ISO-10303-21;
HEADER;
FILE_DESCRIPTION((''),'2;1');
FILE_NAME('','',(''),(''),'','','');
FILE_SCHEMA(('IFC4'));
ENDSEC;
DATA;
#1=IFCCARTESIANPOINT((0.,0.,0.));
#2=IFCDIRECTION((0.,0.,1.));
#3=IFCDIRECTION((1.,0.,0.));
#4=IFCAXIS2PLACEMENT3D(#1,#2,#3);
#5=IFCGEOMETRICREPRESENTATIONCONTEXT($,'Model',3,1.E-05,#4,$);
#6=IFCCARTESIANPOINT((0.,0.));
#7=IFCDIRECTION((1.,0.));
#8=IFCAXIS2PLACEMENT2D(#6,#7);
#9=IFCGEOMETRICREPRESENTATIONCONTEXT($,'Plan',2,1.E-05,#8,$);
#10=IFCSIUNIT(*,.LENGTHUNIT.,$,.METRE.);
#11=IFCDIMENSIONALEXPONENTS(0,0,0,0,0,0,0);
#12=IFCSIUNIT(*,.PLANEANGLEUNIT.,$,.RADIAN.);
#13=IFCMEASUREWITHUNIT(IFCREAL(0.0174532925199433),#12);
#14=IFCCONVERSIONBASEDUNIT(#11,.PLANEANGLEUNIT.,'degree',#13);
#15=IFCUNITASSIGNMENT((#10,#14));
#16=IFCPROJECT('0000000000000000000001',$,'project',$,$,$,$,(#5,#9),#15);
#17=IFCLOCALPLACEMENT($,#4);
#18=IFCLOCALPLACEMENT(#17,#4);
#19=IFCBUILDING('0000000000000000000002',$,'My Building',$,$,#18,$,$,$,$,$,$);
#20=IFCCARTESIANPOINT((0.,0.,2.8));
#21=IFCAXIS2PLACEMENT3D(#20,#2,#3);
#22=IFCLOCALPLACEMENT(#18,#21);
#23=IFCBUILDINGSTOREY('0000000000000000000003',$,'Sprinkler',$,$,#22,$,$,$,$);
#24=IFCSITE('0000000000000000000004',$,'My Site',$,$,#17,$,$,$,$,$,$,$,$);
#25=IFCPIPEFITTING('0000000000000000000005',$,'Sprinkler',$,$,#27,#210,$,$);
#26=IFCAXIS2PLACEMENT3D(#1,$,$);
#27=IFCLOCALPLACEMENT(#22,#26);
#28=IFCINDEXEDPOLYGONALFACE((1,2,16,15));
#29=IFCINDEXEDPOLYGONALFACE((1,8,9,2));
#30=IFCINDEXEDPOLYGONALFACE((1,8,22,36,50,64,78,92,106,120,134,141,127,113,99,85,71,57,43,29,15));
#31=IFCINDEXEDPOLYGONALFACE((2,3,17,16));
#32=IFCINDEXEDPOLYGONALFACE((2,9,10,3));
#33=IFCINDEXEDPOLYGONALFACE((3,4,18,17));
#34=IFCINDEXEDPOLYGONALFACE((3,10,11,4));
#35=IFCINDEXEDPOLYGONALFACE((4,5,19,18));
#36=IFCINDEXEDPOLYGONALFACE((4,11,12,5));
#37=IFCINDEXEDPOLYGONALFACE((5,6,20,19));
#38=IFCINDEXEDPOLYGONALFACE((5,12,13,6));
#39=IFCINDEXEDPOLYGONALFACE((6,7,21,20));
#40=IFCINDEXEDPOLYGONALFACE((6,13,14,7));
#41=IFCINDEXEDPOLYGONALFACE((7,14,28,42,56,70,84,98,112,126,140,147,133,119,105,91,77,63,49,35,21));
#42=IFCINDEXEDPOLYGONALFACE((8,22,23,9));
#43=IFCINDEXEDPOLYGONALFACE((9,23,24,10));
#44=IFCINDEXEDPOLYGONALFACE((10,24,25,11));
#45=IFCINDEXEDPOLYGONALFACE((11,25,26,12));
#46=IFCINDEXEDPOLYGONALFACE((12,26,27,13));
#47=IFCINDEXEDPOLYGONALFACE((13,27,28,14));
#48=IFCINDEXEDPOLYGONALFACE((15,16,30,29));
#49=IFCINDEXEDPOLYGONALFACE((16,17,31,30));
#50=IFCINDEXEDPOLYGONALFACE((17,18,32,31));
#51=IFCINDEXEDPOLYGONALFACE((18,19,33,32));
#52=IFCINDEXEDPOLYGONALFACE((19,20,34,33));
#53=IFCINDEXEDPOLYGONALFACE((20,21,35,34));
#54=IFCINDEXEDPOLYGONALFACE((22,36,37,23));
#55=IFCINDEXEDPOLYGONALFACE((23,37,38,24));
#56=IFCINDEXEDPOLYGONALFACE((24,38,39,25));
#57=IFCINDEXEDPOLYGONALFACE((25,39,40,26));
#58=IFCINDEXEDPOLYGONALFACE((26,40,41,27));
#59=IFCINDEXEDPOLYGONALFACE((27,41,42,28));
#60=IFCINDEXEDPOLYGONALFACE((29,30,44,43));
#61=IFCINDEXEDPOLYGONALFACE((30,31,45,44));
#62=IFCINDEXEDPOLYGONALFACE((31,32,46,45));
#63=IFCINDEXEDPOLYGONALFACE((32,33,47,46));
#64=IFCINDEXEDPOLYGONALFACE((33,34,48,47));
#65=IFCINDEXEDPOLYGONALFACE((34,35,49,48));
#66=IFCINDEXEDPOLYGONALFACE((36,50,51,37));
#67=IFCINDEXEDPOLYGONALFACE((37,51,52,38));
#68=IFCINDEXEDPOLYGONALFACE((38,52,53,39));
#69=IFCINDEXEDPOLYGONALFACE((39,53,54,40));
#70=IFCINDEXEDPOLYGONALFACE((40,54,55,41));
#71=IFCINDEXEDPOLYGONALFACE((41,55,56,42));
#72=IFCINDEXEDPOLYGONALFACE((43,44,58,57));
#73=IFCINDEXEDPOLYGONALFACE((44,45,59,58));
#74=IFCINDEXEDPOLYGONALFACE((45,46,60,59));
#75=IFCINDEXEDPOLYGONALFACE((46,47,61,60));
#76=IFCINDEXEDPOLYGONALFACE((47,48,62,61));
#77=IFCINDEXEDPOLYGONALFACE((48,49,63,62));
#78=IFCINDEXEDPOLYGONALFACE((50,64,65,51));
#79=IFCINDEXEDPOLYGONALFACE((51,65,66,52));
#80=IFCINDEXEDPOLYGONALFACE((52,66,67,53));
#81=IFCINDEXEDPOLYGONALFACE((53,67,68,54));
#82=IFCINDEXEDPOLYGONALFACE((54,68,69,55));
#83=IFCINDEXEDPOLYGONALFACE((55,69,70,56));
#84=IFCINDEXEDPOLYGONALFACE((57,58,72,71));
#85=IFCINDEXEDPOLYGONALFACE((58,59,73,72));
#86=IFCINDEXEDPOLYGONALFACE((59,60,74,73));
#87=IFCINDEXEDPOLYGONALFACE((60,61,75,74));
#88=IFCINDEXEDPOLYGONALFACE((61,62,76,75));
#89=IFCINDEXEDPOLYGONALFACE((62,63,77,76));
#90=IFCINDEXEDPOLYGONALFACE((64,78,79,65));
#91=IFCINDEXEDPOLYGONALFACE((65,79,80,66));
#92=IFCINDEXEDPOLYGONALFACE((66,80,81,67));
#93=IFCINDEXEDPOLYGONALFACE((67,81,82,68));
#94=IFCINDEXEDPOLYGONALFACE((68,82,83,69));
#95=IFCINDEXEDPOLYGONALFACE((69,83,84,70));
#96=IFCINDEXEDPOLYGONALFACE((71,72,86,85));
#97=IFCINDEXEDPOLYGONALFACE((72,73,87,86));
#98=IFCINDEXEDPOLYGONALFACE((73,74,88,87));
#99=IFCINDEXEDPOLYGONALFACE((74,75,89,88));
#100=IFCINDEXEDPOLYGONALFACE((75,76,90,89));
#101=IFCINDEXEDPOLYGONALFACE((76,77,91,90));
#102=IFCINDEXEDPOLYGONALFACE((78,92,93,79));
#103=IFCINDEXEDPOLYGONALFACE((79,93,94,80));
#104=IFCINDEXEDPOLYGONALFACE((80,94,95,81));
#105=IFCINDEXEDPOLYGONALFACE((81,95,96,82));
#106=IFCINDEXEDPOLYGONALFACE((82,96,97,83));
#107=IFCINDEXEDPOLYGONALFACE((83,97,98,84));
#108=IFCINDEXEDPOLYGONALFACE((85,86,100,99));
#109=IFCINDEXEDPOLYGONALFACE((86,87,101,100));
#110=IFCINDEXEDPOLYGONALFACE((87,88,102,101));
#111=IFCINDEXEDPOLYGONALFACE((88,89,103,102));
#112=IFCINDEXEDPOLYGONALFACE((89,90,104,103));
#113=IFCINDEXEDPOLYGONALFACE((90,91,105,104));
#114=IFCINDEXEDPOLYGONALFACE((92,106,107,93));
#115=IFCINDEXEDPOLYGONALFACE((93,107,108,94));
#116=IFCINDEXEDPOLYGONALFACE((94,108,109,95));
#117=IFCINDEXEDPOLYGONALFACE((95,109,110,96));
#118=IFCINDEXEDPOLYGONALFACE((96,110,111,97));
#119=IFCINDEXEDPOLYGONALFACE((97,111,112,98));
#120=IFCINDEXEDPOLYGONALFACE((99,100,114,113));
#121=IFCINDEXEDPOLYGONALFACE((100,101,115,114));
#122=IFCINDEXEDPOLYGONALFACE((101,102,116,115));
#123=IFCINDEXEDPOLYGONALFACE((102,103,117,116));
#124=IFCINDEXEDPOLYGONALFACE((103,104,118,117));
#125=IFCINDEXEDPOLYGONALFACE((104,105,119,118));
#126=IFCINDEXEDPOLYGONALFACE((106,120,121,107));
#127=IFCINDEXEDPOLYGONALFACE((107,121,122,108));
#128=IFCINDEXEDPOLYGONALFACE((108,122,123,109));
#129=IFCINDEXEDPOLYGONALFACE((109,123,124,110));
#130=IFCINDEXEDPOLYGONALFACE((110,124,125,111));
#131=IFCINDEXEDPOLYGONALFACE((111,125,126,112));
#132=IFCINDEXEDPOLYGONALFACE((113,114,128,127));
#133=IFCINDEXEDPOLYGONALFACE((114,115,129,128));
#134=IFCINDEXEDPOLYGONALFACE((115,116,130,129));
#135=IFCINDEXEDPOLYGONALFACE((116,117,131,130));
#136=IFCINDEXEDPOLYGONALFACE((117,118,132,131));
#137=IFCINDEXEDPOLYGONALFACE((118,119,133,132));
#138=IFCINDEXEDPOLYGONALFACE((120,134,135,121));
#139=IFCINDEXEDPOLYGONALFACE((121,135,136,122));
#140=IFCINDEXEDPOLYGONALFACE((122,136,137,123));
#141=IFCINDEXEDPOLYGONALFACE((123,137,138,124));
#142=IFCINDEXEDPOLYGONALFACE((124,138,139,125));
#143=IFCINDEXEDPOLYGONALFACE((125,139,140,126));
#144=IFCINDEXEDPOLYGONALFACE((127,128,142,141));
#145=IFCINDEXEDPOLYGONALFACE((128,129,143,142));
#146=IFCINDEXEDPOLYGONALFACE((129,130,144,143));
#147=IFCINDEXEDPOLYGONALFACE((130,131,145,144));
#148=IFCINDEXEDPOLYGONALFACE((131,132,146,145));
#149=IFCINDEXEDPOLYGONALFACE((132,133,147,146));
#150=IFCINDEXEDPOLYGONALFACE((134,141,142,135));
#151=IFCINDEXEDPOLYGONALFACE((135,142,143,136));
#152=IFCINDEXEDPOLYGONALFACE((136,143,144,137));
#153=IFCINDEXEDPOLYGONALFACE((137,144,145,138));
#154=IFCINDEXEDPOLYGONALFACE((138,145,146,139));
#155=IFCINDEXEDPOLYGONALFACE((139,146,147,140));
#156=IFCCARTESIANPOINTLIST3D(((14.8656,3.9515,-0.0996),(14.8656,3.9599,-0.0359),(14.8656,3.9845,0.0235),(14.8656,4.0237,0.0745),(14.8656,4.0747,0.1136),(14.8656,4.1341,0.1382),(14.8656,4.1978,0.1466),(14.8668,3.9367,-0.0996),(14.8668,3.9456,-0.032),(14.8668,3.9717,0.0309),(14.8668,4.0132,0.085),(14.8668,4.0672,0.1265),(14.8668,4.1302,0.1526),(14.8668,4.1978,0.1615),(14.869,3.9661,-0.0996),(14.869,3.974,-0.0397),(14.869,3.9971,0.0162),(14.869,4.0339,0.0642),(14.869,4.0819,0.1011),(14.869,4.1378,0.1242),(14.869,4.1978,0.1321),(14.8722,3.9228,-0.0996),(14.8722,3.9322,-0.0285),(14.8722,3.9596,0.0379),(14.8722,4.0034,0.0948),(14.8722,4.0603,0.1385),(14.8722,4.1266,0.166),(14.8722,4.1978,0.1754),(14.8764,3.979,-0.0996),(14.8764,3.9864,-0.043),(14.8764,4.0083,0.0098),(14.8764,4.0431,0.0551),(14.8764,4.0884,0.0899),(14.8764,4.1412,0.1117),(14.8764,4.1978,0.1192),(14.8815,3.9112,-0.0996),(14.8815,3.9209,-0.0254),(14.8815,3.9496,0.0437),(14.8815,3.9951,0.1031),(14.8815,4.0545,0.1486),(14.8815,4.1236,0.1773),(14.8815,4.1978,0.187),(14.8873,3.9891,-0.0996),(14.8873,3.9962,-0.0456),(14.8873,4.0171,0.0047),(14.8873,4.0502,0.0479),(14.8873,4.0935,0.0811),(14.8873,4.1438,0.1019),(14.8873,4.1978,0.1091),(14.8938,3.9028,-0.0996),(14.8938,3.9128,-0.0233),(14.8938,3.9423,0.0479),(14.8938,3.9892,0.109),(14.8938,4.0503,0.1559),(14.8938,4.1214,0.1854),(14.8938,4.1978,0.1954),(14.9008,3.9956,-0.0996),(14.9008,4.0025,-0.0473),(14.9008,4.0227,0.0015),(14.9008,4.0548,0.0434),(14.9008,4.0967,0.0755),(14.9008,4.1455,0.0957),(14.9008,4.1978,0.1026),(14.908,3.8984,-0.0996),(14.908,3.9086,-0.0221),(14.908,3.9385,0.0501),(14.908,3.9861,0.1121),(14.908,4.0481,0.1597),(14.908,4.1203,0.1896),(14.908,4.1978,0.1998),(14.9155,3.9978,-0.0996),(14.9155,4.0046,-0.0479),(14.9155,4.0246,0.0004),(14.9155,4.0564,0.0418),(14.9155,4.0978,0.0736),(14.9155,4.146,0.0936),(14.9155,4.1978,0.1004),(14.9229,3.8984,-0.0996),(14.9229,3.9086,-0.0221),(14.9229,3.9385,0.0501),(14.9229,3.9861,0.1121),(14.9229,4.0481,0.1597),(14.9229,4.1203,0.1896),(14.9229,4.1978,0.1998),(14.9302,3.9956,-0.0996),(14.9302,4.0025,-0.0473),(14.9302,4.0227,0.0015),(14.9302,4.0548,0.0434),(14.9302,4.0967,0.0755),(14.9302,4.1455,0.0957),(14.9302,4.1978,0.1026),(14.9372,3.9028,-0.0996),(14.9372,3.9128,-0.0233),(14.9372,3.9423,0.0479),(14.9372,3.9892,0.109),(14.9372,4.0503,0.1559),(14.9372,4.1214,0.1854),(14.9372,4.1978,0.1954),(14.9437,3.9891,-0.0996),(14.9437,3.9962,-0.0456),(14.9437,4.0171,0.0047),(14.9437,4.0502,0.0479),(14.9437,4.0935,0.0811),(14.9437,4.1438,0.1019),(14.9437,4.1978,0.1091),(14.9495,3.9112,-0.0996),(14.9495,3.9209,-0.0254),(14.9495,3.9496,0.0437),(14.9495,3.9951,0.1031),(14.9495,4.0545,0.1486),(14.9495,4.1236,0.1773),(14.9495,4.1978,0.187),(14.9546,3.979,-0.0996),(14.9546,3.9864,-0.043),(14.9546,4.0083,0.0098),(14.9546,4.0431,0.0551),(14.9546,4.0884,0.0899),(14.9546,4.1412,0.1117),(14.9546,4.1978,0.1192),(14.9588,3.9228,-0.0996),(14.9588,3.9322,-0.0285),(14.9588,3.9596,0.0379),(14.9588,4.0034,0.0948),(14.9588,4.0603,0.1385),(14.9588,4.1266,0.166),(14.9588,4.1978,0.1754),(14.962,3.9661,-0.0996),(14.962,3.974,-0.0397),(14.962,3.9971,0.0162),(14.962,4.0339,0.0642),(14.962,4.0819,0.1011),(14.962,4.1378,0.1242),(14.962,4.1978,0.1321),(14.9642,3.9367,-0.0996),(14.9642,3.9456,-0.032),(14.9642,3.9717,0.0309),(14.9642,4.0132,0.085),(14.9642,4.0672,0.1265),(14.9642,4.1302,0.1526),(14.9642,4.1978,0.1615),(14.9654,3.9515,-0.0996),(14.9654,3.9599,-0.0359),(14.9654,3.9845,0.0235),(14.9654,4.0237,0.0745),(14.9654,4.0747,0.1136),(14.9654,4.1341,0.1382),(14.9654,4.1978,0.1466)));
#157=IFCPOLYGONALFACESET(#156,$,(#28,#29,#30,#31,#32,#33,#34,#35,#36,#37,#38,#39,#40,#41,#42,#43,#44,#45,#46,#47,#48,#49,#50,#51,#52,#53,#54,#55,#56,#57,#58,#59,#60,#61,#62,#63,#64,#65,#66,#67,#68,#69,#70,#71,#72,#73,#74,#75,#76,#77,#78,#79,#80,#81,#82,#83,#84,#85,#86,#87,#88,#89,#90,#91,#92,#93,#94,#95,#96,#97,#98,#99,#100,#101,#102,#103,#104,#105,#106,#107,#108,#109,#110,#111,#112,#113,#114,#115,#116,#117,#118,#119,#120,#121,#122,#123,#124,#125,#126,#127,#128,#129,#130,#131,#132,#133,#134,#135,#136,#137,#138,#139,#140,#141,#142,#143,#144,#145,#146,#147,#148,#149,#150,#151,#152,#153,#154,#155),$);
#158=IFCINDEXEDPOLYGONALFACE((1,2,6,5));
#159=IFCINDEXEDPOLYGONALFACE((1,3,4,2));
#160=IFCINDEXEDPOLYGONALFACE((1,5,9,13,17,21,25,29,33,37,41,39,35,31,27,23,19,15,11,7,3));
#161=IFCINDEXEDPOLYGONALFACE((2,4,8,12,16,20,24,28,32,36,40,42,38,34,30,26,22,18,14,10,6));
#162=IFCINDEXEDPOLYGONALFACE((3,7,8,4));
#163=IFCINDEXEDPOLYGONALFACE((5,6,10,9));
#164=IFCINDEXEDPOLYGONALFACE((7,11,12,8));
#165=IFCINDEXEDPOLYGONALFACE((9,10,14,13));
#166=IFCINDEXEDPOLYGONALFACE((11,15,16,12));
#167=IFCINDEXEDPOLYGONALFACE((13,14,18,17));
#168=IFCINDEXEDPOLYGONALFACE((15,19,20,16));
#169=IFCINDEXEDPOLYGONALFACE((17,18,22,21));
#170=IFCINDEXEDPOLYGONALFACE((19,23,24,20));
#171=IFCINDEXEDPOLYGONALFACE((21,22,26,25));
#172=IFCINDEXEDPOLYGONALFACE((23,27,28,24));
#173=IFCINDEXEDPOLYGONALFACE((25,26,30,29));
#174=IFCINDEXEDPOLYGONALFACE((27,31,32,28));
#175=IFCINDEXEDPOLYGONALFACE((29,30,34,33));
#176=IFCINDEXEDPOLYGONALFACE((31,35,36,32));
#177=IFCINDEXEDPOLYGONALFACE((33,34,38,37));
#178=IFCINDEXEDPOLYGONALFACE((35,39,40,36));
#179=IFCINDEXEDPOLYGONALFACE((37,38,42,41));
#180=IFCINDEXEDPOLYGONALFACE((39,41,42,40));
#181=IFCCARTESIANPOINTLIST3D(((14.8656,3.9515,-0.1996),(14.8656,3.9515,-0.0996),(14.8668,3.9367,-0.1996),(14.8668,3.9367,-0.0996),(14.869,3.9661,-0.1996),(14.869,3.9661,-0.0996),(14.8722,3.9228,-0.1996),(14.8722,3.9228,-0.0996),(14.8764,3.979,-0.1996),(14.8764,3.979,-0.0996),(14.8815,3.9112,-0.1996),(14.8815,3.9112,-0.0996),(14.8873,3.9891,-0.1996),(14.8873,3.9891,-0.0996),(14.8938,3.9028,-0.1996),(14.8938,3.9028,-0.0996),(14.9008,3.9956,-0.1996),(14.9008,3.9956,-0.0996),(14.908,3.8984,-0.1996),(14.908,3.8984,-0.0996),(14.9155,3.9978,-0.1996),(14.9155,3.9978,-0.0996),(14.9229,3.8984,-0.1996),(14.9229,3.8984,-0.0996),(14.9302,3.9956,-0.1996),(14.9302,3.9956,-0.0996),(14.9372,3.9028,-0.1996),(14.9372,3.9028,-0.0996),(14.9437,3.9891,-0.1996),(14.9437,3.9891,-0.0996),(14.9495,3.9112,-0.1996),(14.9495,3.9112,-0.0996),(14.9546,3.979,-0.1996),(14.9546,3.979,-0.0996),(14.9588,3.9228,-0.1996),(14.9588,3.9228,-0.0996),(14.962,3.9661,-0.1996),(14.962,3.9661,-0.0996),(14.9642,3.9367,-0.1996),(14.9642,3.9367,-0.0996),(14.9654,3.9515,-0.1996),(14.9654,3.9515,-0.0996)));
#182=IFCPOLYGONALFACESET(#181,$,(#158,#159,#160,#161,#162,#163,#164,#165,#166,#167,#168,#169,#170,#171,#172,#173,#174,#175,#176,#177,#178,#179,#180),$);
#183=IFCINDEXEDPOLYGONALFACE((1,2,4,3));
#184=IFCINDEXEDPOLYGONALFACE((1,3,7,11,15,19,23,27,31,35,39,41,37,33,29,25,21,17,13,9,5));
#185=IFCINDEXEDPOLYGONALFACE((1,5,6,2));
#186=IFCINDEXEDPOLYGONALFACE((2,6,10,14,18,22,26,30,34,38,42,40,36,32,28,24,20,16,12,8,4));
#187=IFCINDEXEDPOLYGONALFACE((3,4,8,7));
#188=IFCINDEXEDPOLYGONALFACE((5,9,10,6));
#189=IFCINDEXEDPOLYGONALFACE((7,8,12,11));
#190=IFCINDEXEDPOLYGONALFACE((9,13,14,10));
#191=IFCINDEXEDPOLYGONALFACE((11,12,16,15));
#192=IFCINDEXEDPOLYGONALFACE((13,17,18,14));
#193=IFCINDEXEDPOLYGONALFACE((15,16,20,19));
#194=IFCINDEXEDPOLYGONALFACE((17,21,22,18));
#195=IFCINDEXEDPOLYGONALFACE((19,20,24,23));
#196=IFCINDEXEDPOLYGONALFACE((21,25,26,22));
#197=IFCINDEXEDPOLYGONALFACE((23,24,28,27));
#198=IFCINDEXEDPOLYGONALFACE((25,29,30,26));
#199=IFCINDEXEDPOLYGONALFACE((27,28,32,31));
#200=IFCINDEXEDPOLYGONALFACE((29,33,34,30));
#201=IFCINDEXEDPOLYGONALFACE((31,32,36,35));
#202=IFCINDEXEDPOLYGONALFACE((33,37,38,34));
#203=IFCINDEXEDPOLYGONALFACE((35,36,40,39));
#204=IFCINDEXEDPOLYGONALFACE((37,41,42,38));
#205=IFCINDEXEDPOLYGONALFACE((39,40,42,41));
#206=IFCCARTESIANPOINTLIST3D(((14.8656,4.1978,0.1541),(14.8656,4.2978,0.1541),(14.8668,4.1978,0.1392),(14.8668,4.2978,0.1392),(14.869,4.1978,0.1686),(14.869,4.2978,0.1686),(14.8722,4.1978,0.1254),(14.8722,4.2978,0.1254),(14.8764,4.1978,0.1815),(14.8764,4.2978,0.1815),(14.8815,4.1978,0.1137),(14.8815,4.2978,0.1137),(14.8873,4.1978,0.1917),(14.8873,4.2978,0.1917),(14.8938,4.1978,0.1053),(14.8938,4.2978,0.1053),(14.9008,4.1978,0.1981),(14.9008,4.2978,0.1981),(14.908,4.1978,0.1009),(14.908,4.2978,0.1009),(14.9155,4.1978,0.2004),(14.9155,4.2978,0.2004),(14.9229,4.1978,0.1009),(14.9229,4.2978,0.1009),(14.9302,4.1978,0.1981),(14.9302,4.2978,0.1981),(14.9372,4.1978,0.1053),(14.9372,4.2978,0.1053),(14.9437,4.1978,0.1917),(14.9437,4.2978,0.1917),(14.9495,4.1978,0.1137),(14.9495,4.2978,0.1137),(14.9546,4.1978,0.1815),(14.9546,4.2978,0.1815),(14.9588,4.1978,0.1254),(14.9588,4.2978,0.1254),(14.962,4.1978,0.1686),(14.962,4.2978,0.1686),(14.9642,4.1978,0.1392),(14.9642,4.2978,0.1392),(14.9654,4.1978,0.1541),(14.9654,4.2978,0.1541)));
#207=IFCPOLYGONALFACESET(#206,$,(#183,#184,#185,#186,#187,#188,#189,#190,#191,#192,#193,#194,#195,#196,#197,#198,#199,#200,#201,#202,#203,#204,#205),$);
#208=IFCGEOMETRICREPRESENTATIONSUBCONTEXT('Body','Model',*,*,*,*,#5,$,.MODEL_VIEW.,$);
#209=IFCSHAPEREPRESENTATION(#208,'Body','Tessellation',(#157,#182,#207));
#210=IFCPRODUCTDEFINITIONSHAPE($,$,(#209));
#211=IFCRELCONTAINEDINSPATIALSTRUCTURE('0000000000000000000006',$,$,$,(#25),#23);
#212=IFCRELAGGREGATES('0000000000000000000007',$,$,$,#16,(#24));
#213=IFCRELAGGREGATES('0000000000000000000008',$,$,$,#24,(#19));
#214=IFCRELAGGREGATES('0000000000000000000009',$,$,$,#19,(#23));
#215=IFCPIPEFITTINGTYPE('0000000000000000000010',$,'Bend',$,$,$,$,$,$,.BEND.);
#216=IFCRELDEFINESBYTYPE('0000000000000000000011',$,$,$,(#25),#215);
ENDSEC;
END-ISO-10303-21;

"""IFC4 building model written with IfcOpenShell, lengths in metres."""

from ifc_helpers import new_model, entity, si_unit, converted_unit, frame, origin_with_axes, origin_2d_with_axis, place, context, subcontext, project, spatial, circle, extrude, source, transform, mapped, type_object, type_shapes, element, save


model = new_model("IFC4")

# Units and contexts
model_context = context("Model", 3, precision=1e-05, world=origin_with_axes())
plan_context = context("Plan", 2, precision=1e-05, world=origin_2d_with_axis())
body_context = subcontext(model_context, "Body", "Model", "MODEL_VIEW")
ifc_project = project(units=[si_unit("LENGTHUNIT", "METRE"), converted_unit("PLANEANGLEUNIT", "degree", entity("IfcReal", 0.0174532925199433), si_unit("PLANEANGLEUNIT", "RADIAN"), dimensions=[0, 0, 0, 0, 0, 0, 0])], contexts=[model_context, plan_context])

# Site, building, storey
site_placement = place(None, origin_with_axes())
site = spatial("IfcSite", under=ifc_project, at=site_placement, Name="My Site")
building_placement = place(site_placement, origin_with_axes())
building = spatial("IfcBuilding", under=site, at=building_placement, Name="My Building")
storey_placement = place(building_placement, frame((0.0, 0.0, 2.8), z_axis=(0.0, 0.0, 1.0), x_axis=(1.0, 0.0, 0.0)))
storey = spatial("IfcBuildingStorey", under=building, at=storey_placement, Name="Sprinkler")

# Pipe fitting
pipe_fitting_type_1 = type_object("IfcPipeFittingType", Name="Bend", PredefinedType="BEND")
shared_shape = source(origin_with_axes(), body_context, "Body", "SolidModel", [
    entity("IfcSweptDiskSolid", entity("IfcIndexedPolyCurve", entity("IfcCartesianPointList3D", [[0.0, 0.0, 0.1], [0.0732, 0.0, 0.2768], [0.25, 0.0, 0.35]]), [entity("IfcArcIndex", [1, 2, 3])]), 0.05),
    extrude(circle(Radius=0.05), origin_with_axes(), (0.0, 0.0, 1.0), 0.1),
    extrude(circle(Radius=0.05), frame((0.25, 0.0, 0.35), z_axis=(1.0, 0.0, 0.000001), x_axis=(-0.000001, 0.0, 1.0)), (0.0, 0.0, 1.0), 0.1),
])
type_shapes(pipe_fitting_type_1, [shared_shape])
for number, where, z_axis, x_axis, name in (
    (1, (14.9155, 3.9478, -0.1996), (0.0, 0.000008, 1.0), (0.0, 1.0, -0.000008), "Sprinkler"),
):
    element("IfcPipeFitting", number, at=place(storey_placement, frame(where, z_axis=z_axis, x_axis=x_axis)), inside=storey, type_object=pipe_fitting_type_1, Name=name, context=body_context, shape_type="MappedRepresentation", body=[
        mapped(shared_shape, transform((0.0, 0.0, 0.0), x_axis=(1.0, 0.0, 0.0), y_axis=(0.0, 1.0, 0.0), z_axis=(0.0, 0.0, 1.0), scale=1.0)),
    ])

save(model, "model.ifc")
